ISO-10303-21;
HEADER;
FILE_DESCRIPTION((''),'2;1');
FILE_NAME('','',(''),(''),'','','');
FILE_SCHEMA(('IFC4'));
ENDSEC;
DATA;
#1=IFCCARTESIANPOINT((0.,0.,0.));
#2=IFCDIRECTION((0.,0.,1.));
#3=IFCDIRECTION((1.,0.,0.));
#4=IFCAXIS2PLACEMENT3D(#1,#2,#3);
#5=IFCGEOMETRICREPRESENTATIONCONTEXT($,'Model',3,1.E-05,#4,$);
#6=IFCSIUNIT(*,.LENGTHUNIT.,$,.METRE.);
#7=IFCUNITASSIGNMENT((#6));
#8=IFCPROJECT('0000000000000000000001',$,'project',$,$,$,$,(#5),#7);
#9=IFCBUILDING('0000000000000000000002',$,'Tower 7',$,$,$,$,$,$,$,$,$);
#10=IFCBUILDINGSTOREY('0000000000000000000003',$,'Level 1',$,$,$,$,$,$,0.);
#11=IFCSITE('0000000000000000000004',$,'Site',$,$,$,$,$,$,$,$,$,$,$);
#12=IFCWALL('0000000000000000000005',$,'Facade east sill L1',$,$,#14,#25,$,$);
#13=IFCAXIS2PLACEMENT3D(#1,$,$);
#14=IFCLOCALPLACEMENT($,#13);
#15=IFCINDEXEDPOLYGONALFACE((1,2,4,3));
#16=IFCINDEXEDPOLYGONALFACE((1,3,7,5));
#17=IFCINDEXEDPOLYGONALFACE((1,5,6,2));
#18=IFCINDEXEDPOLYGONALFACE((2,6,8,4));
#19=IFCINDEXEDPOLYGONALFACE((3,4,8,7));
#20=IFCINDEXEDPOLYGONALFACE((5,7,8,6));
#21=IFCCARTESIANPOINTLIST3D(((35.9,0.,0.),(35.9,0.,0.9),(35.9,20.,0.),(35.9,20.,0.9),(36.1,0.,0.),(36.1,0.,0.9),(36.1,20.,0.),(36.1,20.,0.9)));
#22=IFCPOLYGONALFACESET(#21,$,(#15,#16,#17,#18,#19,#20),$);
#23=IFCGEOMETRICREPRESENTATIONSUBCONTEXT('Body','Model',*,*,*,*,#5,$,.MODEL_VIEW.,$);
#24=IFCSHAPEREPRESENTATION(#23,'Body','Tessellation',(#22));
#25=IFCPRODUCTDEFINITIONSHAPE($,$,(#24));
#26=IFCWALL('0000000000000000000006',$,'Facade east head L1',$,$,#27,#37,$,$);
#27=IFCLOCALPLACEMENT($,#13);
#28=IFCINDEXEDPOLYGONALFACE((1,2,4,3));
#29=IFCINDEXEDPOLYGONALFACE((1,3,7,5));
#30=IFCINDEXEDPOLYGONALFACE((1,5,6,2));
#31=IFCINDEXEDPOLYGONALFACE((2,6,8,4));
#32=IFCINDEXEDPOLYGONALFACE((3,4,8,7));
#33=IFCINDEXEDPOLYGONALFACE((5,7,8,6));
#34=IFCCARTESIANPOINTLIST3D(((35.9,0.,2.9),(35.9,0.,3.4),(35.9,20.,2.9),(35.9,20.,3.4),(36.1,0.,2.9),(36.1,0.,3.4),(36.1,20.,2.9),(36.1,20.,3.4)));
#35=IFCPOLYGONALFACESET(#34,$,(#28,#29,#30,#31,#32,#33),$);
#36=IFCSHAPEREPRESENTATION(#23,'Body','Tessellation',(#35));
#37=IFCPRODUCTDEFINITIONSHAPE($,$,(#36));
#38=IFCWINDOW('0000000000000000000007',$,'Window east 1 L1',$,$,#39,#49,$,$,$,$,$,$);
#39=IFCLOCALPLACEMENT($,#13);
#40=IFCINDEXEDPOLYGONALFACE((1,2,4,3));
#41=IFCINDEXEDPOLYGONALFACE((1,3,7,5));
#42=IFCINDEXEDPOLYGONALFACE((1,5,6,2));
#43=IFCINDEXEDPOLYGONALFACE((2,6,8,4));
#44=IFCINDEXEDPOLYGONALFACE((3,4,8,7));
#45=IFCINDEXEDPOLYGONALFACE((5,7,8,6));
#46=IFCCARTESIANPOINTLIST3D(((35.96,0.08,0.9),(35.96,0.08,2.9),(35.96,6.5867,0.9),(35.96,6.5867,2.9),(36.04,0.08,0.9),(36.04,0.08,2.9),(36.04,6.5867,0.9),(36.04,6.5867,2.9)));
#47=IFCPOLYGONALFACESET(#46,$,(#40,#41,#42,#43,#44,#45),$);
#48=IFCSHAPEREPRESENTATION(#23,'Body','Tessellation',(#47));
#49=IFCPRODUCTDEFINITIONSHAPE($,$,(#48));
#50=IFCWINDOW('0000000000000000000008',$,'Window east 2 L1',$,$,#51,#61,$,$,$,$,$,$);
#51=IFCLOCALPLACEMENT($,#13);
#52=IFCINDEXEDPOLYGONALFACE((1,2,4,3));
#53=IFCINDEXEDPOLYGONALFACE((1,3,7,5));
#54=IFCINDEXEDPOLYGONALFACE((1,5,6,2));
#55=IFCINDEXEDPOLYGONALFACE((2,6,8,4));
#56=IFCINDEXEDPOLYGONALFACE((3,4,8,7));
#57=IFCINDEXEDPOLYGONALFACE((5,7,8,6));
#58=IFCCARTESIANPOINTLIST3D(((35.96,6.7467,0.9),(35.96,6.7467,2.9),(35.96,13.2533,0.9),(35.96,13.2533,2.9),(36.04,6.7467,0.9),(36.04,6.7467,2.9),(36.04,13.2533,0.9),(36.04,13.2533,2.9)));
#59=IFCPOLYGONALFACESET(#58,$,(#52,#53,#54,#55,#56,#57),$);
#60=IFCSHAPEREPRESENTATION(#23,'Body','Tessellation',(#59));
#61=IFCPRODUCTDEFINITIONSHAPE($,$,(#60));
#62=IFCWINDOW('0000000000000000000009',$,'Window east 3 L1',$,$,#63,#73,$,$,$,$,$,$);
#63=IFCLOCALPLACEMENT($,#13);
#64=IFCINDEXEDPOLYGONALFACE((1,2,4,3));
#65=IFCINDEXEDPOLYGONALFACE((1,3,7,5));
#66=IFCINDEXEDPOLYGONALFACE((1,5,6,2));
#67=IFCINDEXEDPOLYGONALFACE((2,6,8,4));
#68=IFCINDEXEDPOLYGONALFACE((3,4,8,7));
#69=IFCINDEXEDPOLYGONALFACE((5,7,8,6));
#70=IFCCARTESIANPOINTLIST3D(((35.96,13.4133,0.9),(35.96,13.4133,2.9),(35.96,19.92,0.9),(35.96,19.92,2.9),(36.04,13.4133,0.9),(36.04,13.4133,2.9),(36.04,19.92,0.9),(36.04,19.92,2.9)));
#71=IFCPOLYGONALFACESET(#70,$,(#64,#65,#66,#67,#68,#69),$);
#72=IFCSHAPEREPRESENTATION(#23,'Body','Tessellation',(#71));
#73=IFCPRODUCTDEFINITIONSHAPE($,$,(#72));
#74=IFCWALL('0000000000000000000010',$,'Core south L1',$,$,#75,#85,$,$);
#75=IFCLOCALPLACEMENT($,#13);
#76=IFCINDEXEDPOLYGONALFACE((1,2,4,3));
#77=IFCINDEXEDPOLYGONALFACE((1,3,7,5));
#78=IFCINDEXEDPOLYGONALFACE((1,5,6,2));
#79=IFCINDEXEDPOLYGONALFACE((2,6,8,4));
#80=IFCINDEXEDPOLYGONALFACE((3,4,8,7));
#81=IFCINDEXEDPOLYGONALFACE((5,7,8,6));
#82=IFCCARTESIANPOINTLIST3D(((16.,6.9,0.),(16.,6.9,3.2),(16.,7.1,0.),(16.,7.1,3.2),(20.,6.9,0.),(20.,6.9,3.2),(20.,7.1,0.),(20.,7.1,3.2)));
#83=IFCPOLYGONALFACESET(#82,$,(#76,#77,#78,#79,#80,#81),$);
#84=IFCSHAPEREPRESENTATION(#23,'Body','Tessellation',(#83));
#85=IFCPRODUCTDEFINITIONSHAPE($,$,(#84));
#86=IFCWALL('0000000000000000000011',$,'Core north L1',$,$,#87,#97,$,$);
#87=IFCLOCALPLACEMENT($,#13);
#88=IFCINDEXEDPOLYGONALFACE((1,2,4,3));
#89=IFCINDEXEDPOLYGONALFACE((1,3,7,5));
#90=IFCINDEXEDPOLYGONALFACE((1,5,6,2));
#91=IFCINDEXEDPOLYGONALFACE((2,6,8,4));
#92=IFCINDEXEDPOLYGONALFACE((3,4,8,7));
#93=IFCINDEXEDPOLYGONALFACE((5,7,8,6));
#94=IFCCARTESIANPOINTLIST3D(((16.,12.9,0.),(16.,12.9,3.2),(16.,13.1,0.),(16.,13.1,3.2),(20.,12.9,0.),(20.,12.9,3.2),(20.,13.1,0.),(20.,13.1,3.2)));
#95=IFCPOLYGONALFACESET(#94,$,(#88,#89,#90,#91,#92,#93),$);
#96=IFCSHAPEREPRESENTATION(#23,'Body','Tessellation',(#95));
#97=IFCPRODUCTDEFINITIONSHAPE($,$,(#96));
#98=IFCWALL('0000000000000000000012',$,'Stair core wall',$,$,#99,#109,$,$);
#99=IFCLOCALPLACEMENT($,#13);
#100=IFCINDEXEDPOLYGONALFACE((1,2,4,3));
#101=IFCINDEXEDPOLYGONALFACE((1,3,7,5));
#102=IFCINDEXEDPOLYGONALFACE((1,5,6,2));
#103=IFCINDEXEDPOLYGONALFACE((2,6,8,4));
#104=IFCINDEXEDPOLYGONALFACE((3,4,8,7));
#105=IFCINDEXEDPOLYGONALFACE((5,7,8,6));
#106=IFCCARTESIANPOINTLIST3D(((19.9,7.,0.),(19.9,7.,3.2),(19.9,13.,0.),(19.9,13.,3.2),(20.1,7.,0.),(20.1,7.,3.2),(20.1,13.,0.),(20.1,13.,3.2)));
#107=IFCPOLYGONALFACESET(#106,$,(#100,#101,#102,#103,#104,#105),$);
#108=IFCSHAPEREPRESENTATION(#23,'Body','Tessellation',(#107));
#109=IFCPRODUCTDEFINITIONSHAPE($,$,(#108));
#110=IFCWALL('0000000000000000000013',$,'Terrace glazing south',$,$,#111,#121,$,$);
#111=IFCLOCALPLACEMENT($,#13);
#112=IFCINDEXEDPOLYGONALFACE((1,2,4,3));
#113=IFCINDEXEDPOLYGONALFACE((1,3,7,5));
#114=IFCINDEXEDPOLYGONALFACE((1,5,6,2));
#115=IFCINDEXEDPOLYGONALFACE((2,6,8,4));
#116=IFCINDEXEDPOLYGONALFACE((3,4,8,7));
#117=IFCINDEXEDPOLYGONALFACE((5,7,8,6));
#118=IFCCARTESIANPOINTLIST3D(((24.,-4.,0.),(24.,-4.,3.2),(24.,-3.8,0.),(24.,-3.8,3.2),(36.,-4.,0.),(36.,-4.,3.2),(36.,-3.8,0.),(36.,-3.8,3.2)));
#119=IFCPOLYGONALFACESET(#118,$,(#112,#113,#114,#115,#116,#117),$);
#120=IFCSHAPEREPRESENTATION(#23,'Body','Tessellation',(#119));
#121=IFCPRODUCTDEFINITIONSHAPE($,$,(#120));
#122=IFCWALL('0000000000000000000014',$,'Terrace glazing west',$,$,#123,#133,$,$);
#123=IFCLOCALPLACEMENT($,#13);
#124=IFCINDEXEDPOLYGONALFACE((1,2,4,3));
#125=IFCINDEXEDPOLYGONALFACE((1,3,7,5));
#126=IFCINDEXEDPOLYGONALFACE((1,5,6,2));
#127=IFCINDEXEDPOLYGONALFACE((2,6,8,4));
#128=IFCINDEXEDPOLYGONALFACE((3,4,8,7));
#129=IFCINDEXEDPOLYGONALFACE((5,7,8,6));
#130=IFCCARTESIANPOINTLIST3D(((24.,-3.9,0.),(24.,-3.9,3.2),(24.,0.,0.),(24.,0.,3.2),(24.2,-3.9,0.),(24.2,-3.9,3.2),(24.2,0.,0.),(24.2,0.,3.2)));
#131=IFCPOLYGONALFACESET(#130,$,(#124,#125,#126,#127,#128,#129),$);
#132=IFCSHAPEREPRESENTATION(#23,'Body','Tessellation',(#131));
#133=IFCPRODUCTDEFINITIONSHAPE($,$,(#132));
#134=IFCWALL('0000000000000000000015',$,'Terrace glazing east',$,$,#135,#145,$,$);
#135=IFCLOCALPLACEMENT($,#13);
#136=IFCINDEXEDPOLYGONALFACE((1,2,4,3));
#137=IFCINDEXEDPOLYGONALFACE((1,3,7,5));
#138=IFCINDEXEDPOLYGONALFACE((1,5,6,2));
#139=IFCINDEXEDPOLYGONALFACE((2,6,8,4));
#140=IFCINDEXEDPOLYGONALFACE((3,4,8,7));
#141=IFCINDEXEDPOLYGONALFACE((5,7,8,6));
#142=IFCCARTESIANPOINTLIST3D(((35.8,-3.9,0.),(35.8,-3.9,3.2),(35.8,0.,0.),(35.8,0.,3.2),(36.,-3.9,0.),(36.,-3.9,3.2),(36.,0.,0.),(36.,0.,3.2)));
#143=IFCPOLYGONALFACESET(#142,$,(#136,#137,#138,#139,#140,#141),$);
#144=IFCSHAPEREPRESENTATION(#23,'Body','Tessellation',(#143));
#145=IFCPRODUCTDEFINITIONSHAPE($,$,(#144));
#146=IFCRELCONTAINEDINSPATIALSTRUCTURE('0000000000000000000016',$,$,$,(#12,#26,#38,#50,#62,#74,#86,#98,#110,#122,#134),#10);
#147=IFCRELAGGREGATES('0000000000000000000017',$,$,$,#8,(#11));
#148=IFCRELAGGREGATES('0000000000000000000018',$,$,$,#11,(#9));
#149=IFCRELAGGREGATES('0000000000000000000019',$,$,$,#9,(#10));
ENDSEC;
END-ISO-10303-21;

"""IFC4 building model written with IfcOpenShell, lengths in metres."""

from ifc_helpers import new_model, si_unit, frame, origin, origin_with_axes, origin_2d, place, context, subcontext, project, spatial, rectangle, extrude, element, save


model = new_model("IFC4")

# Units and contexts
model_context = context("Model", 3, precision=1e-05, world=origin_with_axes())
body_context = subcontext(model_context, "Body", "Model", "MODEL_VIEW")
ifc_project = project(units=[si_unit("LENGTHUNIT", "METRE")], contexts=[model_context])

# Site, building, storey
site = spatial("IfcSite", under=ifc_project, Name="Site")
building = spatial("IfcBuilding", under=site, Name="Tower 7")
storey = spatial("IfcBuildingStorey", under=building, Name="Level 1", Elevation=0.0)

# Walls
wall_1_placement = place(None, frame((36.0, 10.0, 0.0), z_axis=(0.0, 0.0, 1.0), x_axis=(1.0, 0.0, 0.0)))
element("IfcWall", 1, at=wall_1_placement, inside=storey, Name="Facade east sill L1", context=body_context, shape_type="SweptSolid", body=[
    extrude(rectangle(XDim=0.2, YDim=20.0, at=origin_2d()), origin(), (0.0, 0.0, 1.0), 0.9),
])
wall_2_placement = place(None, frame((36.0, 10.0, 2.9), z_axis=(0.0, 0.0, 1.0), x_axis=(1.0, 0.0, 0.0)))
element("IfcWall", 2, at=wall_2_placement, inside=storey, Name="Facade east head L1", context=body_context, shape_type="SweptSolid", body=[
    extrude(rectangle(XDim=0.2, YDim=20.0, at=origin_2d()), origin(), (0.0, 0.0, 1.0), 0.5),
])

# Windows
for number, where, z_axis, x_axis, name in (
    (3, (36.0, 3.3333, 0.9), (0.0, 0.0, 1.0), (1.0, 0.0, 0.0), "Window east 1 L1"),
    (4, (36.0, 10.0, 0.9), (0.0, 0.0, 1.0), (1.0, 0.0, 0.0), "Window east 2 L1"),
):
    element("IfcWindow", number, at=place(None, frame(where, z_axis=z_axis, x_axis=x_axis)), inside=storey, Name=name, context=body_context, shape_type="SweptSolid", body=[
        extrude(rectangle(XDim=0.08, YDim=6.5067, at=origin_2d()), origin(), (0.0, 0.0, 1.0), 2.0),
    ])
window_placement = place(None, frame((36.0, 16.6667, 0.9), z_axis=(0.0, 0.0, 1.0), x_axis=(1.0, 0.0, 0.0)))
element("IfcWindow", 5, at=window_placement, inside=storey, Name="Window east 3 L1", context=body_context, shape_type="SweptSolid", body=[
    extrude(rectangle(XDim=0.08, YDim=6.5067, at=origin_2d()), origin(), (0.0, 0.0, 1.0), 2.0),
])

# Walls
for number, where, z_axis, x_axis, name in (
    (6, (18.0, 7.0, 0.0), (0.0, 0.0, 1.0), (1.0, 0.0, 0.0), "Core south L1"),
    (7, (18.0, 13.0, 0.0), (0.0, 0.0, 1.0), (1.0, 0.0, 0.0), "Core north L1"),
):
    element("IfcWall", number, at=place(None, frame(where, z_axis=z_axis, x_axis=x_axis)), inside=storey, Name=name, context=body_context, shape_type="SweptSolid", body=[
        extrude(rectangle(XDim=4.0, YDim=0.2, at=origin_2d()), origin(), (0.0, 0.0, 1.0), 3.2),
    ])
wall_3_placement = place(None, frame((20.0, 10.0, 0.0), z_axis=(0.0, 0.0, 1.0), x_axis=(1.0, 0.0, 0.0)))
element("IfcWall", 8, at=wall_3_placement, inside=storey, Name="Stair core wall", context=body_context, shape_type="SweptSolid", body=[
    extrude(rectangle(XDim=0.2, YDim=6.0, at=origin_2d()), origin(), (0.0, 0.0, 1.0), 3.2),
])
wall_4_placement = place(None, frame((30.0, -3.9, 0.0), z_axis=(0.0, 0.0, 1.0), x_axis=(1.0, 0.0, 0.0)))
element("IfcWall", 9, at=wall_4_placement, inside=storey, Name="Terrace glazing south", context=body_context, shape_type="SweptSolid", body=[
    extrude(rectangle(XDim=12.0, YDim=0.2, at=origin_2d()), origin(), (0.0, 0.0, 1.0), 3.2),
])
for number, where, z_axis, x_axis, name in (
    (10, (24.1, -1.95, 0.0), (0.0, 0.0, 1.0), (1.0, 0.0, 0.0), "Terrace glazing west"),
    (11, (35.9, -1.95, 0.0), (0.0, 0.0, 1.0), (1.0, 0.0, 0.0), "Terrace glazing east"),
):
    element("IfcWall", number, at=place(None, frame(where, z_axis=z_axis, x_axis=x_axis)), inside=storey, Name=name, context=body_context, shape_type="SweptSolid", body=[
        extrude(rectangle(XDim=0.2, YDim=3.9, at=origin_2d()), origin(), (0.0, 0.0, 1.0), 3.2),
    ])

save(model, "model.ifc")
